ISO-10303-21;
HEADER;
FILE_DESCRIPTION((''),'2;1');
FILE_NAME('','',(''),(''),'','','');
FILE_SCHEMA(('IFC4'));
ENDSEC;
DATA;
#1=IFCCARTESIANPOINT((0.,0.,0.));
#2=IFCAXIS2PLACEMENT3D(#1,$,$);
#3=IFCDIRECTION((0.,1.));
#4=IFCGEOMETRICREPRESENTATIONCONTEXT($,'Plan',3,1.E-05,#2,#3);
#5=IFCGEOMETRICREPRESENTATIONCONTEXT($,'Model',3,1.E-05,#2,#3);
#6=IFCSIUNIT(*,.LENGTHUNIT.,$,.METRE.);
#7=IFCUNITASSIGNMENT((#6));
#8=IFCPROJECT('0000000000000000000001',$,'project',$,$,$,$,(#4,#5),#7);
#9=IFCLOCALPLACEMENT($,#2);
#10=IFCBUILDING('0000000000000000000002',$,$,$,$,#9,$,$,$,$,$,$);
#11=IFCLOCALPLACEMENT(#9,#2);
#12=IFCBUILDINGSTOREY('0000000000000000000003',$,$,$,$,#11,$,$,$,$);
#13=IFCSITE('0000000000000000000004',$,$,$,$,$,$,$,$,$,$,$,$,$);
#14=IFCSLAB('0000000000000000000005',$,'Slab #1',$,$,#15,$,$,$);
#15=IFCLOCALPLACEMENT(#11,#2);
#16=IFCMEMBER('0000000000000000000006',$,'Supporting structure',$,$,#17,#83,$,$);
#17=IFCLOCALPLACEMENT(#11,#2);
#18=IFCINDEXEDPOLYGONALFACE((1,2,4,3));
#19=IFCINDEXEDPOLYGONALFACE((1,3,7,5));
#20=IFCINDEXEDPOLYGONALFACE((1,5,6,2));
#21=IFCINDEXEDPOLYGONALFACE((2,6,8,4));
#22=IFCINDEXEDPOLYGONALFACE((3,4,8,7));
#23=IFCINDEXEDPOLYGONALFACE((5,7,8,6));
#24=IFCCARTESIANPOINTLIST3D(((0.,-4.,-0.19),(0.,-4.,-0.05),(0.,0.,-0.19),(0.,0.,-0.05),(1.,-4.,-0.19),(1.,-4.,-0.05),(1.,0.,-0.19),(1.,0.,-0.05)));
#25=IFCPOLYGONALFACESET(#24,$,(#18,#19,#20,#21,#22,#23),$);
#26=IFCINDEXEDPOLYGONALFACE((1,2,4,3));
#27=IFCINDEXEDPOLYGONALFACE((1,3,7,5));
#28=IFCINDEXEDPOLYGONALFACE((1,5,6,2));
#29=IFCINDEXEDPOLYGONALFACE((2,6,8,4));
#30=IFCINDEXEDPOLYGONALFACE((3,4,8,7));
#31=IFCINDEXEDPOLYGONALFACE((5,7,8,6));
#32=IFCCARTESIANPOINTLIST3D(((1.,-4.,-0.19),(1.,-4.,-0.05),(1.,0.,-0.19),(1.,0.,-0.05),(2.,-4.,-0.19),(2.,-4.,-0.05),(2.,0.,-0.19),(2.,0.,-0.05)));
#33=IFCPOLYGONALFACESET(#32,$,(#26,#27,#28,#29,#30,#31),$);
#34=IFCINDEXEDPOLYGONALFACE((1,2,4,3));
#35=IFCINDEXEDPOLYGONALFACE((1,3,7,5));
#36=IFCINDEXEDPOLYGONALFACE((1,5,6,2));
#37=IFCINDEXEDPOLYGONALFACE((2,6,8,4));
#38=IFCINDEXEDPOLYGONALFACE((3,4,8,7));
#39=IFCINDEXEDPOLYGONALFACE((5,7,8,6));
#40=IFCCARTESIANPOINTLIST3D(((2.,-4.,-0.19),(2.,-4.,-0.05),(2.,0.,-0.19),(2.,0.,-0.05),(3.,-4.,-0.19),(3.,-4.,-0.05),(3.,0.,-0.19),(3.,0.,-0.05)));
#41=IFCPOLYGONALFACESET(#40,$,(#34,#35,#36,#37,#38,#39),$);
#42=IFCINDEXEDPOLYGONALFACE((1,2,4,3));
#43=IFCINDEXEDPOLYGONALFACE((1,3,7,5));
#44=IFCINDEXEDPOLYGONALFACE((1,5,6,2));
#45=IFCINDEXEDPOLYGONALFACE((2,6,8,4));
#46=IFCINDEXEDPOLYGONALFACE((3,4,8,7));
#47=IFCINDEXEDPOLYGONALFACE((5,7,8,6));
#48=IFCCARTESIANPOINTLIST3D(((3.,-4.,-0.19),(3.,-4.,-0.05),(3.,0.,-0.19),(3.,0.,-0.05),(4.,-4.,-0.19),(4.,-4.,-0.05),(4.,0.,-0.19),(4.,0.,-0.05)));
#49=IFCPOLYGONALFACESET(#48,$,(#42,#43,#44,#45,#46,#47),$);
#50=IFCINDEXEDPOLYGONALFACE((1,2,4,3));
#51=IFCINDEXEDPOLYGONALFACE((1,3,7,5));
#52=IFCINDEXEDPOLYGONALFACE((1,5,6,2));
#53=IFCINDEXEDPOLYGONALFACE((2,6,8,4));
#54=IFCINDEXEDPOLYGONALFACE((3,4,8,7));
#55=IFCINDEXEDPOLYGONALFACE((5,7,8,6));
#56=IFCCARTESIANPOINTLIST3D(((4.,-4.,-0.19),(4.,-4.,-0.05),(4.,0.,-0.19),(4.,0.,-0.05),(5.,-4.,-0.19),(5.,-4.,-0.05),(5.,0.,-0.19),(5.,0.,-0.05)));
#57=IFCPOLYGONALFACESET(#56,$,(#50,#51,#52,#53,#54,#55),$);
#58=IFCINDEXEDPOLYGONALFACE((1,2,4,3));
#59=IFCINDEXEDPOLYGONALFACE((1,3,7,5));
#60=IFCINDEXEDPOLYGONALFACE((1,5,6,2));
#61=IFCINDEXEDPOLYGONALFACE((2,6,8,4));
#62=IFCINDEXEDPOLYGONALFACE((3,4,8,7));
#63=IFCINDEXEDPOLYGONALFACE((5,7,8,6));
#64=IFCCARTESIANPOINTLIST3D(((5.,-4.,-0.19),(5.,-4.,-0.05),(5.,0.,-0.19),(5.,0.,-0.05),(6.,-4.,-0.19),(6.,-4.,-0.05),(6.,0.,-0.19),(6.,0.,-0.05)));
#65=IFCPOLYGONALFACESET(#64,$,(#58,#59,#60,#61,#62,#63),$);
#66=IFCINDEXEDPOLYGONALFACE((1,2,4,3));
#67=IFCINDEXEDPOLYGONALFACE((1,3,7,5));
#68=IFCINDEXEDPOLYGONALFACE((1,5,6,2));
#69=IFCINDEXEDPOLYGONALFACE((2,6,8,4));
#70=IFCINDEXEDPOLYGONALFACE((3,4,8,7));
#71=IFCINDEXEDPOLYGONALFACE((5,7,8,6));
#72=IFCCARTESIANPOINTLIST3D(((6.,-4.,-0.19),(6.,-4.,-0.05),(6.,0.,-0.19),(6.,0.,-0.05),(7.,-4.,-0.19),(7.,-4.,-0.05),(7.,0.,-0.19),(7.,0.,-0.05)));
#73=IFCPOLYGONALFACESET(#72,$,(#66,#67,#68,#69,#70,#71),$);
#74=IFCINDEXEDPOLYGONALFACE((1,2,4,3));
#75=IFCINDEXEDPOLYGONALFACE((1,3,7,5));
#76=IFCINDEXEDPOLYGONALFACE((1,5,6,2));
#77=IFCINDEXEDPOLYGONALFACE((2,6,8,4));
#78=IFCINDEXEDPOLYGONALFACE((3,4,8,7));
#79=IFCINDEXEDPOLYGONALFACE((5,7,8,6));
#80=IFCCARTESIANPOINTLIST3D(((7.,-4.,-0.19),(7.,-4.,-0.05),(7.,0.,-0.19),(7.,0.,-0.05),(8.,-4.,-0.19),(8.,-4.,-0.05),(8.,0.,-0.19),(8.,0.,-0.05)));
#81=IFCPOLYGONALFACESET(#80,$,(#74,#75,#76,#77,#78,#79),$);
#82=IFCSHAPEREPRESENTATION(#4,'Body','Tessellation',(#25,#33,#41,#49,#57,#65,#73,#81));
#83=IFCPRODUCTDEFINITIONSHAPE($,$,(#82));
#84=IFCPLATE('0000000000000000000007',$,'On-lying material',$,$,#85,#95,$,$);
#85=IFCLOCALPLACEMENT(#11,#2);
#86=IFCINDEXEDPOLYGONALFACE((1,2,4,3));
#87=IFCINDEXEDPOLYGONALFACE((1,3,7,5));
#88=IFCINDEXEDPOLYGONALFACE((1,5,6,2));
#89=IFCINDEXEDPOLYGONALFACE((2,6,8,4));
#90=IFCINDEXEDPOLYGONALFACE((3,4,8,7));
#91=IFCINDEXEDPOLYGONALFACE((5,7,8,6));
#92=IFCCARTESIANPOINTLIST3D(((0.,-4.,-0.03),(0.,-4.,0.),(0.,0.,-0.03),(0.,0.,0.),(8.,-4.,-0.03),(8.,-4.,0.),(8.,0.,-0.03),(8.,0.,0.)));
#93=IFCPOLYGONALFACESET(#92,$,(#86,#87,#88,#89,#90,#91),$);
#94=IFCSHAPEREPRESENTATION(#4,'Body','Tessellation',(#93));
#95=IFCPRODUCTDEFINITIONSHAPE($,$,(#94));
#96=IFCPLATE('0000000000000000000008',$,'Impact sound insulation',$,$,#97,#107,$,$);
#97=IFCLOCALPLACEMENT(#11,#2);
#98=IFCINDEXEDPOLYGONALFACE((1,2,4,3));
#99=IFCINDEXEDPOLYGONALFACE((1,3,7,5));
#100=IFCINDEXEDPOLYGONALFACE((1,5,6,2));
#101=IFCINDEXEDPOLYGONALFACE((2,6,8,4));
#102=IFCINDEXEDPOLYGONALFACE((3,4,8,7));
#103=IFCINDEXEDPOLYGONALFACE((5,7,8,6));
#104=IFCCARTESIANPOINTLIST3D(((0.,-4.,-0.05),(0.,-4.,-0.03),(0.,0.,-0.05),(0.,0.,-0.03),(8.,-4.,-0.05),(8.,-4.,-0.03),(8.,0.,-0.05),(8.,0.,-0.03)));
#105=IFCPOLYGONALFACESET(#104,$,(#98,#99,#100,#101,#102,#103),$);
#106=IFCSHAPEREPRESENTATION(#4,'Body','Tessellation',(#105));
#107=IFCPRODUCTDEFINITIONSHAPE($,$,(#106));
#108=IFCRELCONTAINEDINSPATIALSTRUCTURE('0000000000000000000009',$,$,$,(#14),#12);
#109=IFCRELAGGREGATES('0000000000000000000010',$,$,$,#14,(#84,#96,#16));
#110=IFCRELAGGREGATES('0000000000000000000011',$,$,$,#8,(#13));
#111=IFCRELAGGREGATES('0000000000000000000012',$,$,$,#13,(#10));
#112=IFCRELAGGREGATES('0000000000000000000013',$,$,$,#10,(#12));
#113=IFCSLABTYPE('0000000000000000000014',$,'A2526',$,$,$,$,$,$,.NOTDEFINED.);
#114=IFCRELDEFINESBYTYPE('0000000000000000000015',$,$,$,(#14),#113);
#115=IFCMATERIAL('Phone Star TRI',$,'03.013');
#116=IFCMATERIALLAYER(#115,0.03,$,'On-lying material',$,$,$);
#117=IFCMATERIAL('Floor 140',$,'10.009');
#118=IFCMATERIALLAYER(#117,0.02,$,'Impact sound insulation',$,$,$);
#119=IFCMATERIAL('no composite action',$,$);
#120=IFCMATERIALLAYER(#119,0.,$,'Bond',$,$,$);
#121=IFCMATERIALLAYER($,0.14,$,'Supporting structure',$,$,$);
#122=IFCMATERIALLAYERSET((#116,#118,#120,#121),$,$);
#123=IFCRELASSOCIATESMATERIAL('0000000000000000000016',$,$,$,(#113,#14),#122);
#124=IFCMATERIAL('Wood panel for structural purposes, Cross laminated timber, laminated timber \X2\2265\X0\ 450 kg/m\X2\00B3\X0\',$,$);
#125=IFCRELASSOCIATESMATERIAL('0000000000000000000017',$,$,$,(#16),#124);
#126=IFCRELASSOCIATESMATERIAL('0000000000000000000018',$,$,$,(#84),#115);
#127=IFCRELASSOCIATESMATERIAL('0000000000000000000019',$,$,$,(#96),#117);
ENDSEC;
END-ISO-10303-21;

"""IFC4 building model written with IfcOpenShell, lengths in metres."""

from ifc_helpers import new_model, si_unit, direction, frame, frame_2d, origin, origin_with_axes, place, context, project, spatial, rectangle, extrude, material, layer, layer_set, type_object, element, aggregate, save


model = new_model("IFC4")

# Units and contexts
plan_context = context("Plan", 3, precision=1e-05, world=origin(), true_north=direction((0.0, 1.0)))
model_context = context("Model", 3, precision=1e-05, world=origin(), true_north=direction((0.0, 1.0)))
ifc_project = project(units=[si_unit("LENGTHUNIT", "METRE")], contexts=[plan_context, model_context])

# Site, building, storey
site = spatial("IfcSite", under=ifc_project)
building_placement = place(None, origin())
building = spatial("IfcBuilding", under=site, at=building_placement)
storey_placement = place(building_placement, origin())
storey = spatial("IfcBuildingStorey", under=building, at=storey_placement)

# Slab, member, plates
ifc_material_1 = material(Name="Phone Star TRI", Category="03.013")
ifc_layer_1 = layer(ifc_material_1, 0.03, Name="On-lying material")
ifc_material_2 = material(Name="Floor 140", Category="10.009")
ifc_layer_2 = layer(ifc_material_2, 0.02, Name="Impact sound insulation")
ifc_material_3 = material(Name="no composite action")
ifc_layer_3 = layer(ifc_material_3, 0.0, Name="Bond")
ifc_layer_4 = layer(None, 0.14, Name="Supporting structure")
ifc_layer_set = layer_set([ifc_layer_1, ifc_layer_2, ifc_layer_3, ifc_layer_4])
slab_type = type_object("IfcSlabType", Name="A2526", PredefinedType="NOTDEFINED", material=ifc_layer_set)
slab_placement = place(None, frame((0.0, 0.0, 0.0), z_axis=(0.0, 0.0, -1.0), x_axis=(1.0, 0.0, 0.0)))
slab = element("IfcSlab", 1, at=slab_placement, inside=storey, type_object=slab_type, material=ifc_layer_set, Name="Slab #1")
ifc_material_4 = material(Name="Wood panel for structural purposes, Cross laminated timber, laminated timber ≥ 450 kg/m³")
member_placement = place(slab_placement, origin())
member = element("IfcMember", 2, at=member_placement, material=ifc_material_4, Name="Supporting structure", context=plan_context, shape_type="SweptSolid", body=[
    extrude(rectangle(XDim=1.0, YDim=0.14, at=frame_2d((0.5, 0.07), x_axis=(1.0, 0.0))), frame((0.0, 4.0, 0.05), z_axis=(0.0, -1.0, 0.0), x_axis=(1.0, 0.0, 0.0)), (0.0, 0.0, 1.0), 4.0),
    extrude(rectangle(XDim=1.0, YDim=0.14, at=frame_2d((0.5, 0.07), x_axis=(1.0, 0.0))), frame((1.0, 4.0, 0.05), z_axis=(0.0, -1.0, 0.0), x_axis=(1.0, 0.0, 0.0)), (0.0, 0.0, 1.0), 4.0),
    extrude(rectangle(XDim=1.0, YDim=0.14, at=frame_2d((0.5, 0.07), x_axis=(1.0, 0.0))), frame((2.0, 4.0, 0.05), z_axis=(0.0, -1.0, 0.0), x_axis=(1.0, 0.0, 0.0)), (0.0, 0.0, 1.0), 4.0),
    extrude(rectangle(XDim=1.0, YDim=0.14, at=frame_2d((0.5, 0.07), x_axis=(1.0, 0.0))), frame((3.0, 4.0, 0.05), z_axis=(0.0, -1.0, 0.0), x_axis=(1.0, 0.0, 0.0)), (0.0, 0.0, 1.0), 4.0),
    extrude(rectangle(XDim=1.0, YDim=0.14, at=frame_2d((0.5, 0.07), x_axis=(1.0, 0.0))), frame((4.0, 4.0, 0.05), z_axis=(0.0, -1.0, 0.0), x_axis=(1.0, 0.0, 0.0)), (0.0, 0.0, 1.0), 4.0),
    extrude(rectangle(XDim=1.0, YDim=0.14, at=frame_2d((0.5, 0.07), x_axis=(1.0, 0.0))), frame((5.0, 4.0, 0.05), z_axis=(0.0, -1.0, 0.0), x_axis=(1.0, 0.0, 0.0)), (0.0, 0.0, 1.0), 4.0),
    extrude(rectangle(XDim=1.0, YDim=0.14, at=frame_2d((0.5, 0.07), x_axis=(1.0, 0.0))), frame((6.0, 4.0, 0.05), z_axis=(0.0, -1.0, 0.0), x_axis=(1.0, 0.0, 0.0)), (0.0, 0.0, 1.0), 4.0),
    extrude(rectangle(XDim=1.0, YDim=0.14, at=frame_2d((0.5, 0.07), x_axis=(1.0, 0.0))), frame((7.0, 4.0, 0.05), z_axis=(0.0, -1.0, 0.0), x_axis=(1.0, 0.0, 0.0)), (0.0, 0.0, 1.0), 4.0),
])
plate_1_placement = place(slab_placement, origin())
plate_1 = element("IfcPlate", 3, at=plate_1_placement, material=ifc_material_1, Name="On-lying material", context=plan_context, shape_type="SweptSolid", body=[
    extrude(rectangle(XDim=8.0, YDim=4.0, at=frame_2d((4.0, 2.0), x_axis=(1.0, 0.0))), origin_with_axes(), (0.0, 0.0, 1.0), 0.03),
])
plate_2_placement = place(slab_placement, origin())
plate_2 = element("IfcPlate", 4, at=plate_2_placement, material=ifc_material_2, Name="Impact sound insulation", context=plan_context, shape_type="SweptSolid", body=[
    extrude(rectangle(XDim=8.0, YDim=4.0, at=frame_2d((4.0, 2.0), x_axis=(1.0, 0.0))), frame((0.0, 0.0, 0.03), z_axis=(0.0, 0.0, 1.0), x_axis=(1.0, 0.0, 0.0)), (0.0, 0.0, 1.0), 0.02),
])
aggregate(slab, [plate_1, plate_2, member])

save(model, "model.ifc")
